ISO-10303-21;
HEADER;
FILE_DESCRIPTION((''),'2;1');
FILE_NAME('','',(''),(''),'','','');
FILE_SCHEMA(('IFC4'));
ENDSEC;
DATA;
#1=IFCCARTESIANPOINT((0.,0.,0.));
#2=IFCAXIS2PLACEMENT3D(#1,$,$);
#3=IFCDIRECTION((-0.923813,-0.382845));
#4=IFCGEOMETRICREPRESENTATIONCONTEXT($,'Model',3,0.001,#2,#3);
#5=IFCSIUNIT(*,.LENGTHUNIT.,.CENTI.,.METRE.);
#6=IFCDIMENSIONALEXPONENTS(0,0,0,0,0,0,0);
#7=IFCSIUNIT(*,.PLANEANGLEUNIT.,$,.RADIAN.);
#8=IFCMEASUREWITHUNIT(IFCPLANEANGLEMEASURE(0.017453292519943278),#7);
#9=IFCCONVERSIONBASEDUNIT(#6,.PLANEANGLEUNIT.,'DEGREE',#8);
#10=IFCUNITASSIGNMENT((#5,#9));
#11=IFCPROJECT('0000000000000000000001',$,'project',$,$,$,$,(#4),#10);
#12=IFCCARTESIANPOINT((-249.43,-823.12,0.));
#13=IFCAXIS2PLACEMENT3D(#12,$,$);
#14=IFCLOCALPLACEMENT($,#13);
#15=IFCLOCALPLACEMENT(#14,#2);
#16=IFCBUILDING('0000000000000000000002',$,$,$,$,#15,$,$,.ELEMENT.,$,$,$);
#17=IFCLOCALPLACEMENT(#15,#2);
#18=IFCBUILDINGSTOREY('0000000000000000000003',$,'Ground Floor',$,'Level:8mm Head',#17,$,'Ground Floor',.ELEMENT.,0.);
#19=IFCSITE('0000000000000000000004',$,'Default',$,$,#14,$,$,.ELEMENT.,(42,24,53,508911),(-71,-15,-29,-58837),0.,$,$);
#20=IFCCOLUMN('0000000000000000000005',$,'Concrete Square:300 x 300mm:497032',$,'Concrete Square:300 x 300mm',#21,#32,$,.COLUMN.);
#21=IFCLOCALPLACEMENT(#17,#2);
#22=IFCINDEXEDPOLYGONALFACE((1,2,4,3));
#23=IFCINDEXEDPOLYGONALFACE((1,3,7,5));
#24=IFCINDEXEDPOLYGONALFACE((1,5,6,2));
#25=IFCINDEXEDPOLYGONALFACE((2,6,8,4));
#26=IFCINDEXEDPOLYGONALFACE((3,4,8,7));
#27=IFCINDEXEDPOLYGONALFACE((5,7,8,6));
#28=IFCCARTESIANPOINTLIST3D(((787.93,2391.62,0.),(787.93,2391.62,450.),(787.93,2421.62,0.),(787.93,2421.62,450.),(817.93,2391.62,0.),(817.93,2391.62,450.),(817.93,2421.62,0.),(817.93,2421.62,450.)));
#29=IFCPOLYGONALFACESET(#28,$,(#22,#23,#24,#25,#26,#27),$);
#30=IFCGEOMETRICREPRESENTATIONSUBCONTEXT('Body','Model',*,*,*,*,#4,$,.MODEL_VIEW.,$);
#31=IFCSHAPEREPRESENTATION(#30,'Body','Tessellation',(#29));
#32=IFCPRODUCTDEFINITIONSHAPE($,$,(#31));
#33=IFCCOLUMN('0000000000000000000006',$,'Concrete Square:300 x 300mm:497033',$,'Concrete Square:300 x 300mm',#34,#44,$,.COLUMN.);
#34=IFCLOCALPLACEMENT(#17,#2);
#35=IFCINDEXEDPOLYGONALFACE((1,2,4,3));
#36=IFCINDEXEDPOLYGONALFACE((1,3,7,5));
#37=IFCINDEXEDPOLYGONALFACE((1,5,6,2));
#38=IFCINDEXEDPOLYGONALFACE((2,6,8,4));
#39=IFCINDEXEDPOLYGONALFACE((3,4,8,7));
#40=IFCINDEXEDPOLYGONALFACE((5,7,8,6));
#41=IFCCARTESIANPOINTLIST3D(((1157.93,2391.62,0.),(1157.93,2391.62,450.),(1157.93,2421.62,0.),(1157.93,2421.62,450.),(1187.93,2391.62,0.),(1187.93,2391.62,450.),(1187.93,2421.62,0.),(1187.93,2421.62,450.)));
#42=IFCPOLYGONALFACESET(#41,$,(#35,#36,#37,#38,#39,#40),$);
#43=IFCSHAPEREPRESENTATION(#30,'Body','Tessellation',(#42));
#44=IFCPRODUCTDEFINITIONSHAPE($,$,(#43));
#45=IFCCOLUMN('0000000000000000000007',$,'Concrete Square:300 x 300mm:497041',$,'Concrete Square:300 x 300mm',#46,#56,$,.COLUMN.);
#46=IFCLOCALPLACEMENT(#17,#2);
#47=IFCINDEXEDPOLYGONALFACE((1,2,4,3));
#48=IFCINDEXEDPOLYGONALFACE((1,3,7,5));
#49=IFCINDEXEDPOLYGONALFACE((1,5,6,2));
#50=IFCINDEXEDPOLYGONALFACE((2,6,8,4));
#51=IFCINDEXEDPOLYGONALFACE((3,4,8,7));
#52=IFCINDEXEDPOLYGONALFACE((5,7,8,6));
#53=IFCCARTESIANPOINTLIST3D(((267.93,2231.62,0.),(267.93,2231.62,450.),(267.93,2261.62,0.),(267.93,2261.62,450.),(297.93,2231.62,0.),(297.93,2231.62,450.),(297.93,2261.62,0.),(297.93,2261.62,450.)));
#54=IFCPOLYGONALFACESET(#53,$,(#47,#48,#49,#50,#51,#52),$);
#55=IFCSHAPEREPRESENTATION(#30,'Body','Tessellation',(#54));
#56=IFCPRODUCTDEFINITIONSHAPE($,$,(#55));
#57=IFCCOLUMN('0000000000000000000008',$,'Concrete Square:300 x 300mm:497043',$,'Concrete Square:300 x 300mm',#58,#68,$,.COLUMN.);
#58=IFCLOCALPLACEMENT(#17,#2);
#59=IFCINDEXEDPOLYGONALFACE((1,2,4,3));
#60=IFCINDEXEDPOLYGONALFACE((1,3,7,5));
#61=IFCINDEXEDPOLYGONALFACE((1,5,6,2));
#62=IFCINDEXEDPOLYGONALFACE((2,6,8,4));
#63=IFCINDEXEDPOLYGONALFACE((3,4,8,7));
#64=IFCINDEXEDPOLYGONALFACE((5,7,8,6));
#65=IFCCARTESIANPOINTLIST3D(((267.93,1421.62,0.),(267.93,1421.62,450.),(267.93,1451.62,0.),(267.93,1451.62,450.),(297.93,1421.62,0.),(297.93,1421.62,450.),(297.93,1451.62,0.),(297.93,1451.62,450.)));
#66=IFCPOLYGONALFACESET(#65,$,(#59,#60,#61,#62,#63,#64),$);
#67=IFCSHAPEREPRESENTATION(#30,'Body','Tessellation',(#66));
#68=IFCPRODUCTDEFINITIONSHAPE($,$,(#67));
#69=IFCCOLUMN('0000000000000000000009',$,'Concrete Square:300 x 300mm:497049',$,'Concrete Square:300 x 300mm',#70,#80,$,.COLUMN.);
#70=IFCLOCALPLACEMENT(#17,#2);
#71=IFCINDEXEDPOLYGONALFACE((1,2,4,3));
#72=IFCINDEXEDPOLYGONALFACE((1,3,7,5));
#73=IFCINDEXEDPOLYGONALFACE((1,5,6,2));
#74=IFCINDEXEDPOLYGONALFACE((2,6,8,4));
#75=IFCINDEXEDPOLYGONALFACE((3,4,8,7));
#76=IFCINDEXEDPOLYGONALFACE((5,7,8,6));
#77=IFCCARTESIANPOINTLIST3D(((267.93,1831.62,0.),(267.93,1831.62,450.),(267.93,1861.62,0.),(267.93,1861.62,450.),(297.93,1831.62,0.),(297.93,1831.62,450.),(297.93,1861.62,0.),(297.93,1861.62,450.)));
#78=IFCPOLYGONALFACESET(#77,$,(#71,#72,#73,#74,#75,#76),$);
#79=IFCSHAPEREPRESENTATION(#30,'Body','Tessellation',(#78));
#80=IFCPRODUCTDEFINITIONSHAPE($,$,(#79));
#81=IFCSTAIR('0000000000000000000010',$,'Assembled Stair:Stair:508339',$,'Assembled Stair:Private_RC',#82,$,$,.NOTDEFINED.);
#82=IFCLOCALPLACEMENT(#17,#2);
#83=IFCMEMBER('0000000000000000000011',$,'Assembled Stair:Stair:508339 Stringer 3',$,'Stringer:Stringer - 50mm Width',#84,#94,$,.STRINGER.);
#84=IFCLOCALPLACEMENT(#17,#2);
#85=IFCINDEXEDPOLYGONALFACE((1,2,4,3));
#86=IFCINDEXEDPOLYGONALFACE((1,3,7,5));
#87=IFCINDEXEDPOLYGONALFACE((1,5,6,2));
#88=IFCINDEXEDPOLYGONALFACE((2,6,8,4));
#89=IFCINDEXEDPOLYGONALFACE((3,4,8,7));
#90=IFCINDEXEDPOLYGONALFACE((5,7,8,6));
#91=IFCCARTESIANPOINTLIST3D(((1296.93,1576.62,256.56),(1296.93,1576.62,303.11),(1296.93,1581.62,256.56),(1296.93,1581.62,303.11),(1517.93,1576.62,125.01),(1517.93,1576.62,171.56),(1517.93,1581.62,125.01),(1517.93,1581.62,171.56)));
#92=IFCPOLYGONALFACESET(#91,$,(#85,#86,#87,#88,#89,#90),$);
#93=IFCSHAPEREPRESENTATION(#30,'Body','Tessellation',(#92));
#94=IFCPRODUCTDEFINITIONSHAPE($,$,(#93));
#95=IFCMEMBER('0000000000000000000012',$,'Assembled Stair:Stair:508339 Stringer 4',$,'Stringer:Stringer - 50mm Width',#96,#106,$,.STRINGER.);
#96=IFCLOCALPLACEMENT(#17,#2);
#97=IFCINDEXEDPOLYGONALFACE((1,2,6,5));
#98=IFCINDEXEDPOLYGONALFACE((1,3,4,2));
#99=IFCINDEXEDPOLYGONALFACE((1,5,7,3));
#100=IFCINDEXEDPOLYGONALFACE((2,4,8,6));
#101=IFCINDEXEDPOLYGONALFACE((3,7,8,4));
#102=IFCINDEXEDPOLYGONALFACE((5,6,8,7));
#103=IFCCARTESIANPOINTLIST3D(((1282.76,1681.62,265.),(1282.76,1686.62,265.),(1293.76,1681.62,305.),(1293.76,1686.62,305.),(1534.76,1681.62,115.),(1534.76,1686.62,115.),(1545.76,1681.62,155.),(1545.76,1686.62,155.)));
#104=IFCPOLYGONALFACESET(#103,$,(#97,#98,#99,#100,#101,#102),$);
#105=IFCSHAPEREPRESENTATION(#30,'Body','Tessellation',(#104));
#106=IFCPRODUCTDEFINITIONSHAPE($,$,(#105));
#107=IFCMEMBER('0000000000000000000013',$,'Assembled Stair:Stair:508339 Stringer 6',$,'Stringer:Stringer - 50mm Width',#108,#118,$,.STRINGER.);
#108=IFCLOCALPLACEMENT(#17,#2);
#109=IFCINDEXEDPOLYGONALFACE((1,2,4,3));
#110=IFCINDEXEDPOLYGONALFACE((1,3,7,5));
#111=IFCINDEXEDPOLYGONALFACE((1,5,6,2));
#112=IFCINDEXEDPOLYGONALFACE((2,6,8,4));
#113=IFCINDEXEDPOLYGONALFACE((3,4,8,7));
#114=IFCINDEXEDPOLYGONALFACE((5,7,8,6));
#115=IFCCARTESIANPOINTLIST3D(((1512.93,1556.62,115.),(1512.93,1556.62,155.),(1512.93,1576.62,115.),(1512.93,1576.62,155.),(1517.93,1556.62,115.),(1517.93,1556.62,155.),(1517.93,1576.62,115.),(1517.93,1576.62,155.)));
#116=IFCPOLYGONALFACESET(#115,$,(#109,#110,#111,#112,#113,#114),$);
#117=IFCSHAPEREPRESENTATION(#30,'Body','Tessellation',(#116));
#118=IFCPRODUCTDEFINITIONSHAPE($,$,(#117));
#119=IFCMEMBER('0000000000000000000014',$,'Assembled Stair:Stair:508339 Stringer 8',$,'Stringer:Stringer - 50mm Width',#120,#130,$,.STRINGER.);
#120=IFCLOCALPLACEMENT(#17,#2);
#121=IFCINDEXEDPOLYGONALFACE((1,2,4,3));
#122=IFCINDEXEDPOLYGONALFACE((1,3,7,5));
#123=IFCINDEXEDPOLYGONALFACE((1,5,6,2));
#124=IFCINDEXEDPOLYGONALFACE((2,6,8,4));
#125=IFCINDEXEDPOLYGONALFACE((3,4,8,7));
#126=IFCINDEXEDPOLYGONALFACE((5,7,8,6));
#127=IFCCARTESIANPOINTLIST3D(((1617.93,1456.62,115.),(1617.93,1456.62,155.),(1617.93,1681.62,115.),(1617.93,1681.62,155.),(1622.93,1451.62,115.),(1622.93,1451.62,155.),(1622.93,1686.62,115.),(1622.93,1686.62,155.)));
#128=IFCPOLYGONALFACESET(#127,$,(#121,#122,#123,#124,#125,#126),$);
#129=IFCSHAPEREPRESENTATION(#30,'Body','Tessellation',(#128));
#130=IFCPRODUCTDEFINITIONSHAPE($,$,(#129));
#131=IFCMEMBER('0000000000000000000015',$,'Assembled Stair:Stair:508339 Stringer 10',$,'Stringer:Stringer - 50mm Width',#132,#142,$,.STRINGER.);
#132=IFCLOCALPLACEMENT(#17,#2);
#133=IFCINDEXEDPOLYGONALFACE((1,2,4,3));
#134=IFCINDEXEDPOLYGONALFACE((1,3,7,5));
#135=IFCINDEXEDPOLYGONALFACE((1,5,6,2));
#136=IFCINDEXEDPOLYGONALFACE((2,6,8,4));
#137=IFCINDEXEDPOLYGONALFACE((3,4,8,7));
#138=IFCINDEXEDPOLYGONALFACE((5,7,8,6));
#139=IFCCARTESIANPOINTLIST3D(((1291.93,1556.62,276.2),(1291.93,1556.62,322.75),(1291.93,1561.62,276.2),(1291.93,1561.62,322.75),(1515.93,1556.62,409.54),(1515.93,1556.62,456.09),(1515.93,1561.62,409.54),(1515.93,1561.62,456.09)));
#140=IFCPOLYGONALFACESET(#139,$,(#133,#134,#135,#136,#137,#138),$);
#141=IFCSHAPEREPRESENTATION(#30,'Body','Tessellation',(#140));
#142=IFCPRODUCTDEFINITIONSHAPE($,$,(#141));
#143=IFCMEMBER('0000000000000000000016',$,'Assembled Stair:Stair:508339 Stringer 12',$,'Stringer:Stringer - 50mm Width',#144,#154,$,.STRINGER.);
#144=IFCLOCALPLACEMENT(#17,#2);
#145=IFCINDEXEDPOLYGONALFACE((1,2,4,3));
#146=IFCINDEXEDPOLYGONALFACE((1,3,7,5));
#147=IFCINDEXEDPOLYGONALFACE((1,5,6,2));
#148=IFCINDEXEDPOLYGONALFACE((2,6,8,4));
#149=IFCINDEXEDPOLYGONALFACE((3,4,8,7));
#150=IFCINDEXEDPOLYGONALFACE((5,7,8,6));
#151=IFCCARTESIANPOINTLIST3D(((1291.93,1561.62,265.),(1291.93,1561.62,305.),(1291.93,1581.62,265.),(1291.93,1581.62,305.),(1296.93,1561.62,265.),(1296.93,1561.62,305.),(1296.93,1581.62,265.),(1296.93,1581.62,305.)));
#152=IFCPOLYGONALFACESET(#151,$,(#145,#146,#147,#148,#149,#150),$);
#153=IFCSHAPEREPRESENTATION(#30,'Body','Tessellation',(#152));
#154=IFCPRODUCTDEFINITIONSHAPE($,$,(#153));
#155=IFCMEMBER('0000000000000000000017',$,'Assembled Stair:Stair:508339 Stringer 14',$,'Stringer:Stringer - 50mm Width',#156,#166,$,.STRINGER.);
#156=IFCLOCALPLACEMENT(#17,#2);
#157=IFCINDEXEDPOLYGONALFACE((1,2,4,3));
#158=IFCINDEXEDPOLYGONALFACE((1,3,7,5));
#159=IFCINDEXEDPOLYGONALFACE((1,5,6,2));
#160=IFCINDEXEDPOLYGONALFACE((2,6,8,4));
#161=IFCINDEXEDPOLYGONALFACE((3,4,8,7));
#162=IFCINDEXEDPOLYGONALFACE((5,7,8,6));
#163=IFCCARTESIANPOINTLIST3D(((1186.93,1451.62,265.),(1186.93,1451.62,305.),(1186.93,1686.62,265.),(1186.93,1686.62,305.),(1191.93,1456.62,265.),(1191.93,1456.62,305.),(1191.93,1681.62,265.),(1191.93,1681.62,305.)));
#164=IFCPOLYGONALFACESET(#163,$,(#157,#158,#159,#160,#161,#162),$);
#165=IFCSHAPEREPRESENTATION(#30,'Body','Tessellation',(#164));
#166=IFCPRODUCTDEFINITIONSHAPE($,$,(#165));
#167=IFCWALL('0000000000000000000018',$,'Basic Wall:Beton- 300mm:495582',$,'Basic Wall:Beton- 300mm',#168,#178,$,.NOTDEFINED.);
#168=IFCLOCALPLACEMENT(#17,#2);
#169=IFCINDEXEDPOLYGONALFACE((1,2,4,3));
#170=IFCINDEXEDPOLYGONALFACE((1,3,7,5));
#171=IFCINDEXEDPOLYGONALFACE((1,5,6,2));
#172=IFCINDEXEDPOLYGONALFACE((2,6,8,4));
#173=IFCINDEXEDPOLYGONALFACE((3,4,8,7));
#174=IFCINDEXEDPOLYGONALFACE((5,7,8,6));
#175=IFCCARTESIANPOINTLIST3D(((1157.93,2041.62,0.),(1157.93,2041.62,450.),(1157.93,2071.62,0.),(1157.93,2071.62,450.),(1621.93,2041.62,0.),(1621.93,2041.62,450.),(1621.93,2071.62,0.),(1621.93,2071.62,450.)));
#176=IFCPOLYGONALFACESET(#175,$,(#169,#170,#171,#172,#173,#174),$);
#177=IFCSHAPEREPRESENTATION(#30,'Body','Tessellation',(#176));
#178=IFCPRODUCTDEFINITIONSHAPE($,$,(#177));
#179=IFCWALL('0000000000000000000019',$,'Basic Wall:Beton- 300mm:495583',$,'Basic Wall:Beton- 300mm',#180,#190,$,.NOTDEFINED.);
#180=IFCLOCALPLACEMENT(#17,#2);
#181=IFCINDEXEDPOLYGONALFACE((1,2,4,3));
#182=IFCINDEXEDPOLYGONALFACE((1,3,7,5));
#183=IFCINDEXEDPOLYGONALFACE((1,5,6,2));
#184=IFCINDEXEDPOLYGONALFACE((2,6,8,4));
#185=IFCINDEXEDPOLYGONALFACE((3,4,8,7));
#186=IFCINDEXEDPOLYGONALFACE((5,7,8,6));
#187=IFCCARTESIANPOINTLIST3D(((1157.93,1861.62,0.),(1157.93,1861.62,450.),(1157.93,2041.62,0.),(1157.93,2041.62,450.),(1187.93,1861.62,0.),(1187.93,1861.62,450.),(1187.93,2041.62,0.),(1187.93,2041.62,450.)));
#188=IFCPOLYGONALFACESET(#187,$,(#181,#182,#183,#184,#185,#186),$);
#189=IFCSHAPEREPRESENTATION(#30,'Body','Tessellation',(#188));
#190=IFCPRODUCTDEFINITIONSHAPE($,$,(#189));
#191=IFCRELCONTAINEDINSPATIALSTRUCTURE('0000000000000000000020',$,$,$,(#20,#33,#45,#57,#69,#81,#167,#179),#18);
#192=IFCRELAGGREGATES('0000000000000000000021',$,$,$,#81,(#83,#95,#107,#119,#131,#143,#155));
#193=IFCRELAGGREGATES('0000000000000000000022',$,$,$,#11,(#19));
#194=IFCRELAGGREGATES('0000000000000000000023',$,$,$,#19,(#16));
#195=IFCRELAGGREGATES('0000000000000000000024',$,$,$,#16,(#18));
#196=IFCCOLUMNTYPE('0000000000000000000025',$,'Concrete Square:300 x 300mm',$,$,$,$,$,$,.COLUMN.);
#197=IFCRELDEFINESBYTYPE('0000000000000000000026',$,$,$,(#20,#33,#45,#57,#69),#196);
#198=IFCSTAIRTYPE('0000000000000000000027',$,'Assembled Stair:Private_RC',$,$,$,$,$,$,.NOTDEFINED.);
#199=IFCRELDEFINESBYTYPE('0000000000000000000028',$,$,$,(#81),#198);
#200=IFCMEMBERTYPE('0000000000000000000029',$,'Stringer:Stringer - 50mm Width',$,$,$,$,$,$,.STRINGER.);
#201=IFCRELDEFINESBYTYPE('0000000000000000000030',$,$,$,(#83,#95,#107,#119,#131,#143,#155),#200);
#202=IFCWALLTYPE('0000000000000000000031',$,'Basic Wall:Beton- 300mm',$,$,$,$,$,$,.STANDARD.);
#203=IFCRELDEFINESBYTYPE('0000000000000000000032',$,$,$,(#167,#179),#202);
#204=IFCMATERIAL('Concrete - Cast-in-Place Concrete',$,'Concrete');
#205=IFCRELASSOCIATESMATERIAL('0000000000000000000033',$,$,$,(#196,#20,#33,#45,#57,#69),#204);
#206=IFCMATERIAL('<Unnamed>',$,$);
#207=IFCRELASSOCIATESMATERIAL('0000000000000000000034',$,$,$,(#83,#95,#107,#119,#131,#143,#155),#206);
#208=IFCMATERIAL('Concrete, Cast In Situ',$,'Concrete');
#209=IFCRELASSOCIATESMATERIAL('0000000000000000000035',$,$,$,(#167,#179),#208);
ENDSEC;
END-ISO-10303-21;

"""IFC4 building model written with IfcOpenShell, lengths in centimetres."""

from ifc_helpers import new_model, entity, si_unit, converted_unit, direction, frame, origin, place, context, subcontext, project, spatial, indexed_curve, outline, extrude, source, transform, mapped, material, type_object, type_shapes, element, aggregate, save


model = new_model("IFC4")

# Units and contexts
model_context = context("Model", 3, precision=0.001, world=origin(), true_north=direction((-0.923813, -0.382845)))
body_context = subcontext(model_context, "Body", "Model", "MODEL_VIEW")
ifc_project = project(units=[si_unit("LENGTHUNIT", "METRE", prefix="CENTI"), converted_unit("PLANEANGLEUNIT", "DEGREE", entity("IfcPlaneAngleMeasure", 0.017453292519943278), si_unit("PLANEANGLEUNIT", "RADIAN"), dimensions=[0, 0, 0, 0, 0, 0, 0])], contexts=[model_context])

# Site, building, storey
site_placement = place(None, frame((-249.43, -823.12, 0.0)))
site = spatial("IfcSite", under=ifc_project, at=site_placement, Name="Default", CompositionType="ELEMENT", RefLatitude=(42, 24, 53, 508911), RefLongitude=(-71, -15, -29, -58837), RefElevation=0.0)
building_placement = place(site_placement, origin())
building = spatial("IfcBuilding", under=site, at=building_placement, CompositionType="ELEMENT")
storey_placement = place(building_placement, origin())
storey = spatial("IfcBuildingStorey", under=building, at=storey_placement, Name="Ground Floor", ObjectType="Level:8mm Head", LongName="Ground Floor", CompositionType="ELEMENT", Elevation=0.0)

# Columns
ifc_material_1 = material(Name="Concrete - Cast-in-Place Concrete", Category="Concrete")
column_type = type_object("IfcColumnType", Name="Concrete Square:300 x 300mm", PredefinedType="COLUMN", material=ifc_material_1)
shared_shape_1 = source(origin(), body_context, "Body", "SweptSolid", [
    extrude(outline(indexed_curve([(-15.0, -15.0), (15.0, -15.0), (15.0, 15.0), (-15.0, 15.0), (-15.0, -15.0)], self_intersect=False)), frame((0.0, 0.0, 0.0), z_axis=(0.0, 0.0, 1.0), x_axis=(-1.0, 0.0, 0.0)), (0.0, 0.0, 1.0), 450.0),
])
type_shapes(column_type, [shared_shape_1])
for number, where, name in (
    (1, (802.93, 2406.62, 0.0), "Concrete Square:300 x 300mm:497032"),
    (2, (1172.93, 2406.62, 0.0), "Concrete Square:300 x 300mm:497033"),
    (3, (282.93, 2246.62, 0.0), "Concrete Square:300 x 300mm:497041"),
    (4, (282.93, 1436.62, 0.0), "Concrete Square:300 x 300mm:497043"),
    (5, (282.93, 1846.62, 0.0), "Concrete Square:300 x 300mm:497049"),
):
    element("IfcColumn", number, at=place(storey_placement, frame(where)), inside=storey, type_object=column_type, material=ifc_material_1, Name=name, ObjectType="Concrete Square:300 x 300mm", PredefinedType="COLUMN", context=body_context, shape_type="MappedRepresentation", body=[
        mapped(shared_shape_1, transform((0.0, 0.0, 0.0), scale=1.0)),
    ])

# Stair, members
stair_type = type_object("IfcStairType", Name="Assembled Stair:Private_RC", PredefinedType="NOTDEFINED")
stair_placement = place(storey_placement, origin())
stair = element("IfcStair", 6, at=stair_placement, inside=storey, type_object=stair_type, Name="Assembled Stair:Stair:508339", ObjectType="Assembled Stair:Private_RC", PredefinedType="NOTDEFINED")
ifc_material_2 = material(Name="<Unnamed>")
member_type = type_object("IfcMemberType", Name="Stringer:Stringer - 50mm Width", PredefinedType="STRINGER")
member_1_placement = place(stair_placement, frame((1296.93, 1576.62, 125.01)))
member_1 = element("IfcMember", 7, at=member_1_placement, type_object=member_type, material=ifc_material_2, Name="Assembled Stair:Stair:508339 Stringer 3", ObjectType="Stringer:Stringer - 50mm Width", PredefinedType="STRINGER", context=body_context, shape_type="SweptSolid", body=[
    extrude(outline(indexed_curve([(-140.5, -20.0), (116.69, -20.0), (140.5, 20.0), (-116.69, 20.0), (-140.5, -20.0)], self_intersect=False)), frame((110.5, 0.0, 89.05), z_axis=(0.0, 1.0, 0.0), x_axis=(-0.859293, 0.0, 0.511484)), (0.0, 0.0, 1.0), 5.0),
])
member_2_placement = place(stair_placement, frame((1282.76, 1681.62, 115.0)))
member_2 = element("IfcMember", 8, at=member_2_placement, type_object=member_type, material=ifc_material_2, Name="Assembled Stair:Stair:508339 Stringer 4", ObjectType="Stringer:Stringer - 50mm Width", PredefinedType="STRINGER", context=body_context, shape_type="SweptSolid", body=[
    extrude(outline(indexed_curve([(-152.13, -20.0), (141.13, -20.0), (152.13, 20.0), (-141.13, 20.0), (-152.13, -20.0)], self_intersect=False)), frame((131.5, 0.0, 95.0), z_axis=(0.0, 1.0, 0.0), x_axis=(-0.859293, 0.0, 0.511484)), (0.0, 0.0, 1.0), 5.0),
])
member_3_placement = place(stair_placement, frame((1512.93, 1556.62, 115.0)))
member_3 = element("IfcMember", 9, at=member_3_placement, type_object=member_type, material=ifc_material_2, Name="Assembled Stair:Stair:508339 Stringer 6", ObjectType="Stringer:Stringer - 50mm Width", PredefinedType="STRINGER", context=body_context, shape_type="SweptSolid", body=[
    extrude(outline(indexed_curve([(-10.0, -2.5), (10.0, -2.5), (10.0, 2.5), (-10.0, 2.5), (-10.0, -2.5)], self_intersect=False)), frame((2.5, 10.0, 0.0), z_axis=(0.0, 0.0, 1.0), x_axis=(0.0, -1.0, 0.0)), (0.0, 0.0, 1.0), 40.0),
])
member_4_placement = place(stair_placement, frame((1617.93, 1451.62, 115.0)))
member_4 = element("IfcMember", 10, at=member_4_placement, type_object=member_type, material=ifc_material_2, Name="Assembled Stair:Stair:508339 Stringer 8", ObjectType="Stringer:Stringer - 50mm Width", PredefinedType="STRINGER", context=body_context, shape_type="SweptSolid", body=[
    extrude(outline(indexed_curve([(-117.5, -2.5), (117.5, -2.5), (112.5, 2.5), (-112.5, 2.5), (-117.5, -2.5)], self_intersect=False)), frame((2.5, 117.5, 0.0), z_axis=(0.0, 0.0, 1.0), x_axis=(0.0, 1.0, 0.0)), (0.0, 0.0, 1.0), 40.0),
])
member_5_placement = place(stair_placement, frame((1291.93, 1556.62, 276.2)))
member_5 = element("IfcMember", 11, at=member_5_placement, type_object=member_type, material=ifc_material_2, Name="Assembled Stair:Stair:508339 Stringer 10", ObjectType="Stringer:Stringer - 50mm Width", PredefinedType="STRINGER", context=body_context, shape_type="SweptSolid", body=[
    extrude(outline(indexed_curve([(-118.43, -20.0), (142.24, -20.0), (118.43, 20.0), (-142.24, 20.0), (-118.43, -20.0)], self_intersect=False)), frame((112.0, 0.0, 89.94), z_axis=(0.0, 1.0, 0.0), x_axis=(0.859293, 0.0, 0.511484)), (0.0, 0.0, 1.0), 5.0),
])
member_6_placement = place(stair_placement, frame((1291.93, 1561.62, 265.0)))
member_6 = element("IfcMember", 12, at=member_6_placement, type_object=member_type, material=ifc_material_2, Name="Assembled Stair:Stair:508339 Stringer 12", ObjectType="Stringer:Stringer - 50mm Width", PredefinedType="STRINGER", context=body_context, shape_type="SweptSolid", body=[
    extrude(outline(indexed_curve([(-10.0, -2.5), (10.0, -2.5), (10.0, 2.5), (-10.0, 2.5), (-10.0, -2.5)], self_intersect=False)), frame((2.5, 10.0, 0.0), z_axis=(0.0, 0.0, 1.0), x_axis=(0.0, 1.0, 0.0)), (0.0, 0.0, 1.0), 40.0),
])
member_7_placement = place(stair_placement, frame((1186.93, 1451.62, 265.0)))
member_7 = element("IfcMember", 13, at=member_7_placement, type_object=member_type, material=ifc_material_2, Name="Assembled Stair:Stair:508339 Stringer 14", ObjectType="Stringer:Stringer - 50mm Width", PredefinedType="STRINGER", context=body_context, shape_type="SweptSolid", body=[
    extrude(outline(indexed_curve([(-117.5, -2.5), (117.5, -2.5), (112.5, 2.5), (-112.5, 2.5), (-117.5, -2.5)], self_intersect=False)), frame((2.5, 117.5, 0.0), z_axis=(0.0, 0.0, 1.0), x_axis=(0.0, -1.0, 0.0)), (0.0, 0.0, 1.0), 40.0),
])

# Walls
ifc_material_3 = material(Name="Concrete, Cast In Situ", Category="Concrete")
wall_type_1 = type_object("IfcWallType", Name="Basic Wall:Beton- 300mm", PredefinedType="STANDARD")
wall_1_placement = place(storey_placement, frame((1621.93, 2056.62, 0.0), z_axis=(0.0, 0.0, 1.0), x_axis=(-1.0, 0.0, 0.0)))
element("IfcWall", 14, at=wall_1_placement, inside=storey, type_object=wall_type_1, material=ifc_material_3, Name="Basic Wall:Beton- 300mm:495582", ObjectType="Basic Wall:Beton- 300mm", PredefinedType="NOTDEFINED", context=body_context, shape_type="SweptSolid", body=[
    extrude(outline(indexed_curve([(464.0, 15.0), (0.0, 15.0), (0.0, -15.0), (464.0, -15.0), (464.0, 15.0)], self_intersect=False)), origin(), (0.0, 0.0, 1.0), 450.0),
])
wall_2_placement = place(storey_placement, frame((1172.93, 2041.62, 0.0), z_axis=(0.0, 0.0, 1.0), x_axis=(0.0, -1.0, 0.0)))
element("IfcWall", 15, at=wall_2_placement, inside=storey, type_object=wall_type_1, material=ifc_material_3, Name="Basic Wall:Beton- 300mm:495583", ObjectType="Basic Wall:Beton- 300mm", PredefinedType="NOTDEFINED", context=body_context, shape_type="SweptSolid", body=[
    extrude(outline(indexed_curve([(180.0, 15.0), (0.0, 15.0), (0.0, -15.0), (180.0, -15.0), (180.0, 15.0)], self_intersect=False)), origin(), (0.0, 0.0, 1.0), 450.0),
])

aggregate(stair, [member_1, member_2, member_3, member_4, member_5, member_6, member_7])

save(model, "model.ifc")
